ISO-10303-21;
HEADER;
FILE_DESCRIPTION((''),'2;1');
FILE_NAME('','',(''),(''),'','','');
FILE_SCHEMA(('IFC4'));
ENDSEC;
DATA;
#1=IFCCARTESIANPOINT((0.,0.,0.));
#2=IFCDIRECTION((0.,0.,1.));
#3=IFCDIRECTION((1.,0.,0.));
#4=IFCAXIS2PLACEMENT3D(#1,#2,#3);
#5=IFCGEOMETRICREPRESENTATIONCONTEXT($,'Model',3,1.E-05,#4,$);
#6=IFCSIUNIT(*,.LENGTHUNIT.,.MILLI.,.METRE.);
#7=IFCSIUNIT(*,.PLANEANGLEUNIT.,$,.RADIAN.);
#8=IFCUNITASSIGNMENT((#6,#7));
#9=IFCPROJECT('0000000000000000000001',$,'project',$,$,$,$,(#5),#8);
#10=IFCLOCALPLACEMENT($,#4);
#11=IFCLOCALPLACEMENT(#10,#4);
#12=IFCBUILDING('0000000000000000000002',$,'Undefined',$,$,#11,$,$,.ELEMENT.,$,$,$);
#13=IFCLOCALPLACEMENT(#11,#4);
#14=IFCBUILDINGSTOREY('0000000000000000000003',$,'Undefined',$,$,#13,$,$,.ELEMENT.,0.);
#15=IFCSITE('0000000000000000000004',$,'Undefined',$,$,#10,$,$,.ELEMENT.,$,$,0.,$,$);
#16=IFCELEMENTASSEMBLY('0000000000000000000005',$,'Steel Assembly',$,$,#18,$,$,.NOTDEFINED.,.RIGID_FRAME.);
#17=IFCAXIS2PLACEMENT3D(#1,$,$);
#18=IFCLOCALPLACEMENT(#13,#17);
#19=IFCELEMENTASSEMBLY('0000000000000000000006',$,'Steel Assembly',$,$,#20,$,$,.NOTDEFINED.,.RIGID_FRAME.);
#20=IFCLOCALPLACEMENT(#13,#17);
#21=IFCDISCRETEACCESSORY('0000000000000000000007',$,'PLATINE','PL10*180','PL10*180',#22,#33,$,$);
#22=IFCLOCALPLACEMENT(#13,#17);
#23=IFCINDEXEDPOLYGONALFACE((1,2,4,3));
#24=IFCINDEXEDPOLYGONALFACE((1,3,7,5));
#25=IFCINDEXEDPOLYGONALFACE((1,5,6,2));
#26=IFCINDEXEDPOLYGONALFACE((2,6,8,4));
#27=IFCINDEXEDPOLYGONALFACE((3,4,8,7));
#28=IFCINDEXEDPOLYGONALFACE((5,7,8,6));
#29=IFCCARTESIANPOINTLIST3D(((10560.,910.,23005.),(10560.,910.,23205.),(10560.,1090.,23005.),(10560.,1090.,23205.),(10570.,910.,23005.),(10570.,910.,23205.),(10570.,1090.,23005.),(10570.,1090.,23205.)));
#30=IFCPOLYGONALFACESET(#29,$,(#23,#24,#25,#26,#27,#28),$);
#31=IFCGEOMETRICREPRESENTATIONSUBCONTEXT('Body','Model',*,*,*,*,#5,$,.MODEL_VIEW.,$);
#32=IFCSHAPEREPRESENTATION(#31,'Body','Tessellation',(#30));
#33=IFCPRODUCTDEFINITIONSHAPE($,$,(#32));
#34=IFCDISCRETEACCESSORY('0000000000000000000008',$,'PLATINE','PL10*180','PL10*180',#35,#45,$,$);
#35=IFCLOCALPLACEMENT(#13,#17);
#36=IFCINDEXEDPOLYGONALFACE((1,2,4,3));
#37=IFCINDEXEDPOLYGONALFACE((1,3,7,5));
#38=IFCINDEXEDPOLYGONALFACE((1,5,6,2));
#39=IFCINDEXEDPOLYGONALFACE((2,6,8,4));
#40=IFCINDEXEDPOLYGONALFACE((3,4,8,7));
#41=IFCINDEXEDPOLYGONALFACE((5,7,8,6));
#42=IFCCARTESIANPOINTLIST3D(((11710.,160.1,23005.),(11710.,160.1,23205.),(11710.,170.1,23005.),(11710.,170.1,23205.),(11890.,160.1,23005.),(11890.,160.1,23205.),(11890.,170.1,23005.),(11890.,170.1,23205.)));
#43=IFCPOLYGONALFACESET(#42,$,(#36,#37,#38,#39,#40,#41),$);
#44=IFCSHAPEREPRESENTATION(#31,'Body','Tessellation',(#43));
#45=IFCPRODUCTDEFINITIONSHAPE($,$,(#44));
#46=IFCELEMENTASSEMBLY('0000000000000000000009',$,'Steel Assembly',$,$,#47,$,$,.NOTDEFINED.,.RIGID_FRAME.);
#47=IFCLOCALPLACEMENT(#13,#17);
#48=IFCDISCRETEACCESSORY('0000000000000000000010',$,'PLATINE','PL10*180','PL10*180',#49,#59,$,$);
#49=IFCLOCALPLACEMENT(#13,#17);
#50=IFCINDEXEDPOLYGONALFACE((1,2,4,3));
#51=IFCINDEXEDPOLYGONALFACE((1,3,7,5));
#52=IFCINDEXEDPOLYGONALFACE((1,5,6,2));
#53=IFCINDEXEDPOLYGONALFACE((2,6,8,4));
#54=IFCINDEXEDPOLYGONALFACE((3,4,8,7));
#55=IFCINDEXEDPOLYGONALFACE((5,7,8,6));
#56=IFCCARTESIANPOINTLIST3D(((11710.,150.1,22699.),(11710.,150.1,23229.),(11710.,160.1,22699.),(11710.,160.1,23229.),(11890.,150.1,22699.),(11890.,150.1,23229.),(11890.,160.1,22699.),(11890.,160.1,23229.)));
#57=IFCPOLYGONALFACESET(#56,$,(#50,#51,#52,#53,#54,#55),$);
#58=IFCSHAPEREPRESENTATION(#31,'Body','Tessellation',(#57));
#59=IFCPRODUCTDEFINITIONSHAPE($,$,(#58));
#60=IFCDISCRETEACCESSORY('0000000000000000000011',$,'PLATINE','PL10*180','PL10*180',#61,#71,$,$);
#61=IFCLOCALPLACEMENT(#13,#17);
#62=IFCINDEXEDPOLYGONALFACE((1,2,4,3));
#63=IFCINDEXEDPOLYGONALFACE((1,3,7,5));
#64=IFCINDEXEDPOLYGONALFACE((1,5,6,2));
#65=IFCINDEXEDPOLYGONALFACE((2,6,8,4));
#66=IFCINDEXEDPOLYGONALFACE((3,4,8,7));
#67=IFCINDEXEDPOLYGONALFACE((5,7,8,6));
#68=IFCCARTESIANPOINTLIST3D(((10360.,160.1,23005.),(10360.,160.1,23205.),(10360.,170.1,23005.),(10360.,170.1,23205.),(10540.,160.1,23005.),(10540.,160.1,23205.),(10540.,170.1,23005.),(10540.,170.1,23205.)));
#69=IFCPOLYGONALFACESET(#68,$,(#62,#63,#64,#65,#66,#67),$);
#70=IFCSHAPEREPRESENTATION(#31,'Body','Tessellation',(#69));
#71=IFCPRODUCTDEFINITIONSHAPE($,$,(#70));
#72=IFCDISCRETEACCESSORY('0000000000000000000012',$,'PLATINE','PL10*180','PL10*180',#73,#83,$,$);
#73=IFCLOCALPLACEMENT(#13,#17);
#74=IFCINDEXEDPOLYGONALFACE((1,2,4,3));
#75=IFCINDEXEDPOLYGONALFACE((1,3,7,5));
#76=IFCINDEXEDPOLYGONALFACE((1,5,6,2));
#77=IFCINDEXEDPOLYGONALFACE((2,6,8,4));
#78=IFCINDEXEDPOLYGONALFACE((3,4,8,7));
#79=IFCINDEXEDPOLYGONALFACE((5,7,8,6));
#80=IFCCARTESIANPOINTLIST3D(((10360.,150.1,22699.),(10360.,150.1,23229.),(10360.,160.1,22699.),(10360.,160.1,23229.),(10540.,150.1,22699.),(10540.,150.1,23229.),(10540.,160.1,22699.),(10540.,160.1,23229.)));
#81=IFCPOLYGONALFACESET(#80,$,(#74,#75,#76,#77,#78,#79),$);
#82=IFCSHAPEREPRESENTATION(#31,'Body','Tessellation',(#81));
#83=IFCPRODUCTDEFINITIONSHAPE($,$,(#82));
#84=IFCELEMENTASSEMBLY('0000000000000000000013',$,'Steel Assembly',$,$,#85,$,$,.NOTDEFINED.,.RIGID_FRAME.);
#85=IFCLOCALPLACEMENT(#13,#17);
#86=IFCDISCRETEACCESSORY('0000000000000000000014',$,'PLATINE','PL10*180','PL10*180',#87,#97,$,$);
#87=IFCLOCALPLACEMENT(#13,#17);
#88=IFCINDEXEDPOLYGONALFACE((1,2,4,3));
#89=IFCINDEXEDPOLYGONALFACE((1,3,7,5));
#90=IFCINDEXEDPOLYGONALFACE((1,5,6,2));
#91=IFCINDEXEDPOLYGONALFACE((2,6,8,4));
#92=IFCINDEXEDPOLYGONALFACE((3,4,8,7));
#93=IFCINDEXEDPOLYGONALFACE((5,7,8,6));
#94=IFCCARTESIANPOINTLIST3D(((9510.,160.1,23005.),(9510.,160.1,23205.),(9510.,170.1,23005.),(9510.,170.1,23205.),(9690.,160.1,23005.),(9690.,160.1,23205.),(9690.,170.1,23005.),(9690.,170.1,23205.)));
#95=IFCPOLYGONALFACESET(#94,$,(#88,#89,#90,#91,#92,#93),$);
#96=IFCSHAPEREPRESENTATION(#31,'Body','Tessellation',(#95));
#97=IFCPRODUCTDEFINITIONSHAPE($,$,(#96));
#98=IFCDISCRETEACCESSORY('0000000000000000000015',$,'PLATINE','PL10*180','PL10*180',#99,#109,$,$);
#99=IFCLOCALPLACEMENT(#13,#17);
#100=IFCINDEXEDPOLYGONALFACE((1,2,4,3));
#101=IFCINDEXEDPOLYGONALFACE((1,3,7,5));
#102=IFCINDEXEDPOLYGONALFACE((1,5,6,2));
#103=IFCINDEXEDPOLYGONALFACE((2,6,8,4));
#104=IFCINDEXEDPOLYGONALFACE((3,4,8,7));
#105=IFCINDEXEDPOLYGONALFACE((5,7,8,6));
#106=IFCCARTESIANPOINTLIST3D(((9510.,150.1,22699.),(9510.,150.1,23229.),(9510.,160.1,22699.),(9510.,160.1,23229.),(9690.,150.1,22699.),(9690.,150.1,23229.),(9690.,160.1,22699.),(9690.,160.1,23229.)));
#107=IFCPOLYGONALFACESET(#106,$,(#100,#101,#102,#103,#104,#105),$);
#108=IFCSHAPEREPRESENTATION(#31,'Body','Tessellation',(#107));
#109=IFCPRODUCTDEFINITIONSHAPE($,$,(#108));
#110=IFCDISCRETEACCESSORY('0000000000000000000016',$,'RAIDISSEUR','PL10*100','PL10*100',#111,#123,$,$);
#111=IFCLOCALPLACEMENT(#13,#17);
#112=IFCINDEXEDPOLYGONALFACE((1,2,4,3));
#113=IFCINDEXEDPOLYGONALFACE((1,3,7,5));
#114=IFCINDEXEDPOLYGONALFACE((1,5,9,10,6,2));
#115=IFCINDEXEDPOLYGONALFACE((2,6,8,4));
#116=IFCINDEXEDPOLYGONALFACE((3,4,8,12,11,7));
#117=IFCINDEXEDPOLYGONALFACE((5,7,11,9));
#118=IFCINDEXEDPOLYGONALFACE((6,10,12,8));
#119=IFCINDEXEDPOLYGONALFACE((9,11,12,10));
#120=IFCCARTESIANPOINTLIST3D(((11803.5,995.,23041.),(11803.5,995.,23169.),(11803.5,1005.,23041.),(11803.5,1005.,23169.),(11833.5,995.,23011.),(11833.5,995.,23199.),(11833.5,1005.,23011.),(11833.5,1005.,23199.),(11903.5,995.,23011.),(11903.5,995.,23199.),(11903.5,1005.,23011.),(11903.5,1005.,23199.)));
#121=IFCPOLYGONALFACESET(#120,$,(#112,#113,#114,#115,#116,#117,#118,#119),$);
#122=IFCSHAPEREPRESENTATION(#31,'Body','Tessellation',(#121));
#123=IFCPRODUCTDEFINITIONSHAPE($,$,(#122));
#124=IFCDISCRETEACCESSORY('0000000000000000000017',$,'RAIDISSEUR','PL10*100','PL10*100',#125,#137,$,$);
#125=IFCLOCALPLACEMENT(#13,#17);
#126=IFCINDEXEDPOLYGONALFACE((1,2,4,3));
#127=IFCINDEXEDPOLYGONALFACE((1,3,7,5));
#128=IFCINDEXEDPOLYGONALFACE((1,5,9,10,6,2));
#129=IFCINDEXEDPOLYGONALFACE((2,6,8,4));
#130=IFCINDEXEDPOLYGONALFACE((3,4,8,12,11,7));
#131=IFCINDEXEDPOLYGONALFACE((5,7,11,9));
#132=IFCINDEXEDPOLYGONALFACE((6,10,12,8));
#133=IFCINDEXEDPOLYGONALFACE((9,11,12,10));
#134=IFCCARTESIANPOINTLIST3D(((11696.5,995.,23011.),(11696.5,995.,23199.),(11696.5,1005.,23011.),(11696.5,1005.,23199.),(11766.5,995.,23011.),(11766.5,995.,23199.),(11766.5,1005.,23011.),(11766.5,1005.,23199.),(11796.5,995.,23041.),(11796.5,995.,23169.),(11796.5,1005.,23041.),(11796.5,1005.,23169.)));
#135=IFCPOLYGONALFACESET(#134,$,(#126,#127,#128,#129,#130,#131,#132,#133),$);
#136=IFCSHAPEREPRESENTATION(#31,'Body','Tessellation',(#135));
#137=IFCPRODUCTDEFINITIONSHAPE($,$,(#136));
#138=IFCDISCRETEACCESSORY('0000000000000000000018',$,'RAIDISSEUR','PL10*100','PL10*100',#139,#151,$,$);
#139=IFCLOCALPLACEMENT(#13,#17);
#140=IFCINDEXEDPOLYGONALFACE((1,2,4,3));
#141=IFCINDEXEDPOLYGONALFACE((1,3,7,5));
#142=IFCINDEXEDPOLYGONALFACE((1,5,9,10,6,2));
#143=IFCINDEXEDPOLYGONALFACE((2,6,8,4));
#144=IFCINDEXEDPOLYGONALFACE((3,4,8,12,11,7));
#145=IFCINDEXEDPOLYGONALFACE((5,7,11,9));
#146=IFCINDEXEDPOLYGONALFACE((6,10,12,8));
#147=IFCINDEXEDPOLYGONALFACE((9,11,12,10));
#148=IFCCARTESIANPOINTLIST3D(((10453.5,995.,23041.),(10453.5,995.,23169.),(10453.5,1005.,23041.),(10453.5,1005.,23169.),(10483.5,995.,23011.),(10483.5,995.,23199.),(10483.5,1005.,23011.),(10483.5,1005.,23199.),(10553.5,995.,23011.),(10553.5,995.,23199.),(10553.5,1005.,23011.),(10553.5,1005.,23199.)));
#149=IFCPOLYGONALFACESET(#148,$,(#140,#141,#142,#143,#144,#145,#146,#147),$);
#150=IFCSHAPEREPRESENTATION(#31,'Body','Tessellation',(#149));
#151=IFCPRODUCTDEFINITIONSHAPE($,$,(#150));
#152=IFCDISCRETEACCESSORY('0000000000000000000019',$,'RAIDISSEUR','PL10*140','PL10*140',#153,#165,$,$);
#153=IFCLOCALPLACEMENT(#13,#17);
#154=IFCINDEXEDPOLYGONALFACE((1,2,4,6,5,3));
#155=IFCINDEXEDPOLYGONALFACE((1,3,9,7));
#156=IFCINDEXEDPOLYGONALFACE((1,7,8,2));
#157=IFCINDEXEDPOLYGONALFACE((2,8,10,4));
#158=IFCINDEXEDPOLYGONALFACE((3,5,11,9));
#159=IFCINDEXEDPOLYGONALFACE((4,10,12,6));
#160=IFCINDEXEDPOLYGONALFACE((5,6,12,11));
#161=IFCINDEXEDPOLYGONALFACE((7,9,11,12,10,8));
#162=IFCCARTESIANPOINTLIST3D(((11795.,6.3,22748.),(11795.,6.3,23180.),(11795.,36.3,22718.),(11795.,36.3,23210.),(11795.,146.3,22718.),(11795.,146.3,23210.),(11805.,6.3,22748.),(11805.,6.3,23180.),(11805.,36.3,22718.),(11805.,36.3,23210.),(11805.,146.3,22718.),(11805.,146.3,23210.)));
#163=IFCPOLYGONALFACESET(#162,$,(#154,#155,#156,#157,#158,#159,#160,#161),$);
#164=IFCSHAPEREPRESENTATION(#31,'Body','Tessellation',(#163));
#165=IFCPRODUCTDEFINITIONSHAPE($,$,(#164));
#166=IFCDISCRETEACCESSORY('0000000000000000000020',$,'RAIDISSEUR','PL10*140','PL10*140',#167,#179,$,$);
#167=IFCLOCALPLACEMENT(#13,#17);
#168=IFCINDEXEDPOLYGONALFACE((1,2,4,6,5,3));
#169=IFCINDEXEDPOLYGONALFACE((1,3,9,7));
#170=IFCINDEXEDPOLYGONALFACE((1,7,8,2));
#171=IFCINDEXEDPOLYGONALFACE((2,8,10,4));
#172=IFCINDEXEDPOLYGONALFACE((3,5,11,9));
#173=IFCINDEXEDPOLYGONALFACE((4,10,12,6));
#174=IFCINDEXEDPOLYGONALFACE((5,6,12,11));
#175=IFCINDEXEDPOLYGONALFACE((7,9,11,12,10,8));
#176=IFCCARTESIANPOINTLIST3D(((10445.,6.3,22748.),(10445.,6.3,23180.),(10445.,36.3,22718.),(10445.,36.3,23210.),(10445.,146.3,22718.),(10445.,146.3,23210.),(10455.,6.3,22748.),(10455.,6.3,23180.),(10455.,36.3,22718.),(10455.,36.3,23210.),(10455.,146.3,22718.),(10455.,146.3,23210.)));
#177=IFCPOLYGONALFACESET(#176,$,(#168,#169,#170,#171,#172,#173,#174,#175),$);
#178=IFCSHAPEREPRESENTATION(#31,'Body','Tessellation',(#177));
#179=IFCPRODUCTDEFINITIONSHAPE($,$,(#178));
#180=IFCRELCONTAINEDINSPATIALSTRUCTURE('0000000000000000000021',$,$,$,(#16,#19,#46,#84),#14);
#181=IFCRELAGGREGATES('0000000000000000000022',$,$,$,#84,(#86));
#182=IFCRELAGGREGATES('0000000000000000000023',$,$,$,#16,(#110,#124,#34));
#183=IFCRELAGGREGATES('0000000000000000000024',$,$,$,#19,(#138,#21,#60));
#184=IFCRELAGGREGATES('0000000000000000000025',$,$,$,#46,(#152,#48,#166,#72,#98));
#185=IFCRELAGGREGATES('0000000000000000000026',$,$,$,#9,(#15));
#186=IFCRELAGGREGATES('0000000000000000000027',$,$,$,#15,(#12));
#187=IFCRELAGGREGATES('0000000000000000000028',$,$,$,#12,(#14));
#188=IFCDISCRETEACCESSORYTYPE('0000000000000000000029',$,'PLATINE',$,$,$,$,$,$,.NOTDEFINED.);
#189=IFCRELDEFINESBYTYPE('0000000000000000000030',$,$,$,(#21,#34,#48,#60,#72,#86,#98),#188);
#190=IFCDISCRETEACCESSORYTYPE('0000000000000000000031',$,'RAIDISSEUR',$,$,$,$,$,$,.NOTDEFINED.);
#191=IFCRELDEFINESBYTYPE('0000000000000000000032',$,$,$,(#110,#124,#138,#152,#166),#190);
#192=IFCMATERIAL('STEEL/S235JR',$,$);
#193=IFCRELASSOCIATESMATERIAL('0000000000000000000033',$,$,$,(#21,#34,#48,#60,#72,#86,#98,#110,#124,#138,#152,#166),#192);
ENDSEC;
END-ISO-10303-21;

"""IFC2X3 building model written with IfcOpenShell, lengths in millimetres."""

from ifc_helpers import new_model, si_unit, frame, origin_with_axes, place, context, subcontext, project, spatial, polyline, outline, extrude, material, type_object, element, aggregate, save


model = new_model("IFC2X3")

# Units and contexts
model_context = context("Model", 3, precision=1e-05, world=origin_with_axes())
body_context = subcontext(model_context, "Body", "Model", "MODEL_VIEW")
ifc_project = project(units=[si_unit("LENGTHUNIT", "METRE", prefix="MILLI"), si_unit("PLANEANGLEUNIT", "RADIAN")], contexts=[model_context])

# Site, building, storey
site_placement = place(None, origin_with_axes())
site = spatial("IfcSite", under=ifc_project, at=site_placement, Name="Undefined", CompositionType="ELEMENT", RefElevation=0.0)
building_placement = place(site_placement, origin_with_axes())
building = spatial("IfcBuilding", under=site, at=building_placement, Name="Undefined", CompositionType="ELEMENT")
storey_placement = place(building_placement, origin_with_axes())
storey = spatial("IfcBuildingStorey", under=building, at=storey_placement, Name="Undefined", CompositionType="ELEMENT", Elevation=0.0)

# Shared definitions
ifc_material_1 = material(Name="STEEL/S235JR")

# Shared definitions
discrete_accessory_type_1 = type_object("IfcDiscreteAccessoryType", Name="PLATINE")

# Element assembly
assembly_1_placement = place(storey_placement, origin_with_axes())
assembly_1 = element("IfcElementAssembly", 1, at=assembly_1_placement, inside=storey, Name="Steel Assembly", AssemblyPlace="NOTDEFINED", PredefinedType="RIGID_FRAME")

# Element assembly, discrete accessory
assembly_2_placement = place(storey_placement, origin_with_axes())
assembly_2 = element("IfcElementAssembly", 2, at=assembly_2_placement, inside=storey, Name="Steel Assembly", AssemblyPlace="NOTDEFINED", PredefinedType="RIGID_FRAME")
discrete_accessory_1_placement = place(assembly_2_placement, frame((10565.0, 1000.0, 23005.0), z_axis=(1.0, 0.0, 0.0), x_axis=(0.0, 0.0, 1.0)))
discrete_accessory_1 = element("IfcDiscreteAccessory", 3, at=discrete_accessory_1_placement, type_object=discrete_accessory_type_1, material=ifc_material_1, Name="PLATINE", Description="PL10*180", ObjectType="PL10*180", context=body_context, shape_type="SweptSolid", body=[
    extrude(outline(polyline([(200.0, 90.0), (200.0, -90.0), (0.0, -90.0), (0.0, 90.0), (200.0, 90.0)])), frame((0.0, 0.0, -5.0), z_axis=(0.0, 0.0, 1.0), x_axis=(1.0, 0.0, 0.0)), (0.0, 0.0, 1.0), 10.0),
])

# Discrete accessory
discrete_accessory_2_placement = place(assembly_1_placement, frame((11800.0, 165.1, 23005.0), z_axis=(-0.000008, 1.0, 0.0), x_axis=(0.0, 0.0, 1.0)))
discrete_accessory_2 = element("IfcDiscreteAccessory", 4, at=discrete_accessory_2_placement, type_object=discrete_accessory_type_1, material=ifc_material_1, Name="PLATINE", Description="PL10*180", ObjectType="PL10*180", context=body_context, shape_type="SweptSolid", body=[
    extrude(outline(polyline([(0.0, 90.0), (200.0, 90.0), (200.0, -90.0), (0.0, -90.0), (0.0, 90.0)])), frame((0.0, 0.0, -5.0), z_axis=(0.0, 0.0, 1.0), x_axis=(1.0, 0.0, 0.0)), (0.0, 0.0, 1.0), 10.0),
])

# Element assembly, discrete accessory
assembly_3_placement = place(storey_placement, origin_with_axes())
assembly_3 = element("IfcElementAssembly", 5, at=assembly_3_placement, inside=storey, Name="Steel Assembly", AssemblyPlace="NOTDEFINED", PredefinedType="RIGID_FRAME")
discrete_accessory_3_placement = place(assembly_3_placement, frame((11800.0, 155.1, 22699.0), z_axis=(-0.000008, 1.0, 0.0), x_axis=(0.0, 0.0, 1.0)))
discrete_accessory_3 = element("IfcDiscreteAccessory", 6, at=discrete_accessory_3_placement, type_object=discrete_accessory_type_1, material=ifc_material_1, Name="PLATINE", Description="PL10*180", ObjectType="PL10*180", context=body_context, shape_type="SweptSolid", body=[
    extrude(outline(polyline([(0.0, 90.0), (530.0, 90.0), (530.0, -90.0), (0.0, -90.0), (0.0, 90.0)])), frame((0.0, 0.0, -5.0), z_axis=(0.0, 0.0, 1.0), x_axis=(1.0, 0.0, 0.0)), (0.0, 0.0, 1.0), 10.0),
])

# Discrete accessories
discrete_accessory_4_placement = place(assembly_2_placement, frame((10450.0, 165.1, 23005.0), z_axis=(-0.000008, 1.0, 0.0), x_axis=(0.0, 0.0, 1.0)))
discrete_accessory_4 = element("IfcDiscreteAccessory", 7, at=discrete_accessory_4_placement, type_object=discrete_accessory_type_1, material=ifc_material_1, Name="PLATINE", Description="PL10*180", ObjectType="PL10*180", context=body_context, shape_type="SweptSolid", body=[
    extrude(outline(polyline([(0.0, 90.0), (200.0, 90.0), (200.0, -90.0), (0.0, -90.0), (0.0, 90.0)])), frame((0.0, 0.0, -5.0), z_axis=(0.0, 0.0, 1.0), x_axis=(1.0, 0.0, 0.0)), (0.0, 0.0, 1.0), 10.0),
])
discrete_accessory_5_placement = place(assembly_3_placement, frame((10450.0, 155.1, 22699.0), z_axis=(-0.000008, 1.0, 0.0), x_axis=(0.0, 0.0, 1.0)))
discrete_accessory_5 = element("IfcDiscreteAccessory", 8, at=discrete_accessory_5_placement, type_object=discrete_accessory_type_1, material=ifc_material_1, Name="PLATINE", Description="PL10*180", ObjectType="PL10*180", context=body_context, shape_type="SweptSolid", body=[
    extrude(outline(polyline([(0.0, 90.0), (530.0, 90.0), (530.0, -90.0), (0.0, -90.0), (0.0, 90.0)])), frame((0.0, 0.0, -5.0), z_axis=(0.0, 0.0, 1.0), x_axis=(1.0, 0.0, 0.0)), (0.0, 0.0, 1.0), 10.0),
])

# Element assembly, discrete accessory
assembly_4_placement = place(storey_placement, origin_with_axes())
assembly_4 = element("IfcElementAssembly", 9, at=assembly_4_placement, inside=storey, Name="Steel Assembly", AssemblyPlace="NOTDEFINED", PredefinedType="RIGID_FRAME")
discrete_accessory_6_placement = place(assembly_4_placement, frame((9600.0, 165.1, 23005.0), z_axis=(-0.000008, 1.0, 0.0), x_axis=(0.0, 0.0, 1.0)))
discrete_accessory_6 = element("IfcDiscreteAccessory", 10, at=discrete_accessory_6_placement, type_object=discrete_accessory_type_1, material=ifc_material_1, Name="PLATINE", Description="PL10*180", ObjectType="PL10*180", context=body_context, shape_type="SweptSolid", body=[
    extrude(outline(polyline([(0.0, 90.0), (200.0, 90.0), (200.0, -90.0), (0.0, -90.0), (0.0, 90.0)])), frame((0.0, 0.0, -5.0), z_axis=(0.0, 0.0, 1.0), x_axis=(1.0, 0.0, 0.0)), (0.0, 0.0, 1.0), 10.0),
])
aggregate(assembly_4, [discrete_accessory_6])

# Discrete accessories
discrete_accessory_7_placement = place(assembly_3_placement, frame((9600.0, 155.1, 22699.0), z_axis=(-0.000008, 1.0, 0.0), x_axis=(0.0, 0.0, 1.0)))
discrete_accessory_7 = element("IfcDiscreteAccessory", 11, at=discrete_accessory_7_placement, type_object=discrete_accessory_type_1, material=ifc_material_1, Name="PLATINE", Description="PL10*180", ObjectType="PL10*180", context=body_context, shape_type="SweptSolid", body=[
    extrude(outline(polyline([(0.0, 90.0), (530.0, 90.0), (530.0, -90.0), (0.0, -90.0), (0.0, 90.0)])), frame((0.0, 0.0, -5.0), z_axis=(0.0, 0.0, 1.0), x_axis=(1.0, 0.0, 0.0)), (0.0, 0.0, 1.0), 10.0),
])
discrete_accessory_type_2 = type_object("IfcDiscreteAccessoryType", Name="RAIDISSEUR")
discrete_accessory_8_placement = place(assembly_1_placement, frame((11803.5, 1000.0, 23011.0), z_axis=(0.0, -1.0, 0.0), x_axis=(1.0, 0.0, 0.0)))
discrete_accessory_8 = element("IfcDiscreteAccessory", 12, at=discrete_accessory_8_placement, type_object=discrete_accessory_type_2, material=ifc_material_1, Name="RAIDISSEUR", Description="PL10*100", ObjectType="PL10*100", context=body_context, shape_type="SweptSolid", body=[
    extrude(outline(polyline([(0.0, 30.0), (30.0, 0.0), (100.0, 0.0), (100.0, 188.0), (30.0, 188.0), (0.0, 158.0), (0.0, 30.0)])), frame((0.0, 0.0, -5.0), z_axis=(0.0, 0.0, 1.0), x_axis=(1.0, 0.0, 0.0)), (0.0, 0.0, 1.0), 10.0),
])
discrete_accessory_9_placement = place(assembly_1_placement, frame((11796.5, 1000.0, 23011.0), z_axis=(0.0, 1.0, 0.0), x_axis=(-1.0, 0.0, 0.0)))
discrete_accessory_9 = element("IfcDiscreteAccessory", 13, at=discrete_accessory_9_placement, type_object=discrete_accessory_type_2, material=ifc_material_1, Name="RAIDISSEUR", Description="PL10*100", ObjectType="PL10*100", context=body_context, shape_type="SweptSolid", body=[
    extrude(outline(polyline([(0.0, 30.0), (30.0, 0.0), (100.0, 0.0), (100.0, 188.0), (30.0, 188.0), (0.0, 158.0), (0.0, 30.0)])), frame((0.0, 0.0, -5.0), z_axis=(0.0, 0.0, 1.0), x_axis=(1.0, 0.0, 0.0)), (0.0, 0.0, 1.0), 10.0),
])
aggregate(assembly_1, [discrete_accessory_8, discrete_accessory_9, discrete_accessory_2])
discrete_accessory_10_placement = place(assembly_2_placement, frame((10453.5, 1000.0, 23011.0), z_axis=(0.0, -1.0, 0.0), x_axis=(1.0, 0.0, 0.0)))
discrete_accessory_10 = element("IfcDiscreteAccessory", 14, at=discrete_accessory_10_placement, type_object=discrete_accessory_type_2, material=ifc_material_1, Name="RAIDISSEUR", Description="PL10*100", ObjectType="PL10*100", context=body_context, shape_type="SweptSolid", body=[
    extrude(outline(polyline([(0.0, 30.0), (30.0, 0.0), (100.0, 0.0), (100.0, 188.0), (30.0, 188.0), (0.0, 158.0), (0.0, 30.0)])), frame((0.0, 0.0, -5.0), z_axis=(0.0, 0.0, 1.0), x_axis=(1.0, 0.0, 0.0)), (0.0, 0.0, 1.0), 10.0),
])
aggregate(assembly_2, [discrete_accessory_10, discrete_accessory_1, discrete_accessory_4])
discrete_accessory_11_placement = place(assembly_3_placement, frame((11800.0, 6.3, 22718.0), z_axis=(1.0, 0.000008, 0.0), x_axis=(-0.000008, 1.0, 0.0)))
discrete_accessory_11 = element("IfcDiscreteAccessory", 15, at=discrete_accessory_11_placement, type_object=discrete_accessory_type_2, material=ifc_material_1, Name="RAIDISSEUR", Description="PL10*140", ObjectType="PL10*140", context=body_context, shape_type="SweptSolid", body=[
    extrude(outline(polyline([(0.0, 30.0), (30.0, 0.0), (140.0, 0.0), (140.0, 492.0), (30.0, 492.0), (0.0, 462.0), (0.0, 30.0)])), frame((0.0, 0.0, -5.0), z_axis=(0.0, 0.0, 1.0), x_axis=(1.0, 0.0, 0.0)), (0.0, 0.0, 1.0), 10.0),
])
discrete_accessory_12_placement = place(assembly_3_placement, frame((10450.0, 6.3, 22718.0), z_axis=(1.0, 0.000008, 0.0), x_axis=(-0.000008, 1.0, 0.0)))
discrete_accessory_12 = element("IfcDiscreteAccessory", 16, at=discrete_accessory_12_placement, type_object=discrete_accessory_type_2, material=ifc_material_1, Name="RAIDISSEUR", Description="PL10*140", ObjectType="PL10*140", context=body_context, shape_type="SweptSolid", body=[
    extrude(outline(polyline([(0.0, 30.0), (30.0, 0.0), (140.0, 0.0), (140.0, 492.0), (30.0, 492.0), (0.0, 462.0), (0.0, 30.0)])), frame((0.0, 0.0, -5.0), z_axis=(0.0, 0.0, 1.0), x_axis=(1.0, 0.0, 0.0)), (0.0, 0.0, 1.0), 10.0),
])

aggregate(assembly_3, [discrete_accessory_11, discrete_accessory_3, discrete_accessory_12, discrete_accessory_5, discrete_accessory_7])

save(model, "model.ifc")
